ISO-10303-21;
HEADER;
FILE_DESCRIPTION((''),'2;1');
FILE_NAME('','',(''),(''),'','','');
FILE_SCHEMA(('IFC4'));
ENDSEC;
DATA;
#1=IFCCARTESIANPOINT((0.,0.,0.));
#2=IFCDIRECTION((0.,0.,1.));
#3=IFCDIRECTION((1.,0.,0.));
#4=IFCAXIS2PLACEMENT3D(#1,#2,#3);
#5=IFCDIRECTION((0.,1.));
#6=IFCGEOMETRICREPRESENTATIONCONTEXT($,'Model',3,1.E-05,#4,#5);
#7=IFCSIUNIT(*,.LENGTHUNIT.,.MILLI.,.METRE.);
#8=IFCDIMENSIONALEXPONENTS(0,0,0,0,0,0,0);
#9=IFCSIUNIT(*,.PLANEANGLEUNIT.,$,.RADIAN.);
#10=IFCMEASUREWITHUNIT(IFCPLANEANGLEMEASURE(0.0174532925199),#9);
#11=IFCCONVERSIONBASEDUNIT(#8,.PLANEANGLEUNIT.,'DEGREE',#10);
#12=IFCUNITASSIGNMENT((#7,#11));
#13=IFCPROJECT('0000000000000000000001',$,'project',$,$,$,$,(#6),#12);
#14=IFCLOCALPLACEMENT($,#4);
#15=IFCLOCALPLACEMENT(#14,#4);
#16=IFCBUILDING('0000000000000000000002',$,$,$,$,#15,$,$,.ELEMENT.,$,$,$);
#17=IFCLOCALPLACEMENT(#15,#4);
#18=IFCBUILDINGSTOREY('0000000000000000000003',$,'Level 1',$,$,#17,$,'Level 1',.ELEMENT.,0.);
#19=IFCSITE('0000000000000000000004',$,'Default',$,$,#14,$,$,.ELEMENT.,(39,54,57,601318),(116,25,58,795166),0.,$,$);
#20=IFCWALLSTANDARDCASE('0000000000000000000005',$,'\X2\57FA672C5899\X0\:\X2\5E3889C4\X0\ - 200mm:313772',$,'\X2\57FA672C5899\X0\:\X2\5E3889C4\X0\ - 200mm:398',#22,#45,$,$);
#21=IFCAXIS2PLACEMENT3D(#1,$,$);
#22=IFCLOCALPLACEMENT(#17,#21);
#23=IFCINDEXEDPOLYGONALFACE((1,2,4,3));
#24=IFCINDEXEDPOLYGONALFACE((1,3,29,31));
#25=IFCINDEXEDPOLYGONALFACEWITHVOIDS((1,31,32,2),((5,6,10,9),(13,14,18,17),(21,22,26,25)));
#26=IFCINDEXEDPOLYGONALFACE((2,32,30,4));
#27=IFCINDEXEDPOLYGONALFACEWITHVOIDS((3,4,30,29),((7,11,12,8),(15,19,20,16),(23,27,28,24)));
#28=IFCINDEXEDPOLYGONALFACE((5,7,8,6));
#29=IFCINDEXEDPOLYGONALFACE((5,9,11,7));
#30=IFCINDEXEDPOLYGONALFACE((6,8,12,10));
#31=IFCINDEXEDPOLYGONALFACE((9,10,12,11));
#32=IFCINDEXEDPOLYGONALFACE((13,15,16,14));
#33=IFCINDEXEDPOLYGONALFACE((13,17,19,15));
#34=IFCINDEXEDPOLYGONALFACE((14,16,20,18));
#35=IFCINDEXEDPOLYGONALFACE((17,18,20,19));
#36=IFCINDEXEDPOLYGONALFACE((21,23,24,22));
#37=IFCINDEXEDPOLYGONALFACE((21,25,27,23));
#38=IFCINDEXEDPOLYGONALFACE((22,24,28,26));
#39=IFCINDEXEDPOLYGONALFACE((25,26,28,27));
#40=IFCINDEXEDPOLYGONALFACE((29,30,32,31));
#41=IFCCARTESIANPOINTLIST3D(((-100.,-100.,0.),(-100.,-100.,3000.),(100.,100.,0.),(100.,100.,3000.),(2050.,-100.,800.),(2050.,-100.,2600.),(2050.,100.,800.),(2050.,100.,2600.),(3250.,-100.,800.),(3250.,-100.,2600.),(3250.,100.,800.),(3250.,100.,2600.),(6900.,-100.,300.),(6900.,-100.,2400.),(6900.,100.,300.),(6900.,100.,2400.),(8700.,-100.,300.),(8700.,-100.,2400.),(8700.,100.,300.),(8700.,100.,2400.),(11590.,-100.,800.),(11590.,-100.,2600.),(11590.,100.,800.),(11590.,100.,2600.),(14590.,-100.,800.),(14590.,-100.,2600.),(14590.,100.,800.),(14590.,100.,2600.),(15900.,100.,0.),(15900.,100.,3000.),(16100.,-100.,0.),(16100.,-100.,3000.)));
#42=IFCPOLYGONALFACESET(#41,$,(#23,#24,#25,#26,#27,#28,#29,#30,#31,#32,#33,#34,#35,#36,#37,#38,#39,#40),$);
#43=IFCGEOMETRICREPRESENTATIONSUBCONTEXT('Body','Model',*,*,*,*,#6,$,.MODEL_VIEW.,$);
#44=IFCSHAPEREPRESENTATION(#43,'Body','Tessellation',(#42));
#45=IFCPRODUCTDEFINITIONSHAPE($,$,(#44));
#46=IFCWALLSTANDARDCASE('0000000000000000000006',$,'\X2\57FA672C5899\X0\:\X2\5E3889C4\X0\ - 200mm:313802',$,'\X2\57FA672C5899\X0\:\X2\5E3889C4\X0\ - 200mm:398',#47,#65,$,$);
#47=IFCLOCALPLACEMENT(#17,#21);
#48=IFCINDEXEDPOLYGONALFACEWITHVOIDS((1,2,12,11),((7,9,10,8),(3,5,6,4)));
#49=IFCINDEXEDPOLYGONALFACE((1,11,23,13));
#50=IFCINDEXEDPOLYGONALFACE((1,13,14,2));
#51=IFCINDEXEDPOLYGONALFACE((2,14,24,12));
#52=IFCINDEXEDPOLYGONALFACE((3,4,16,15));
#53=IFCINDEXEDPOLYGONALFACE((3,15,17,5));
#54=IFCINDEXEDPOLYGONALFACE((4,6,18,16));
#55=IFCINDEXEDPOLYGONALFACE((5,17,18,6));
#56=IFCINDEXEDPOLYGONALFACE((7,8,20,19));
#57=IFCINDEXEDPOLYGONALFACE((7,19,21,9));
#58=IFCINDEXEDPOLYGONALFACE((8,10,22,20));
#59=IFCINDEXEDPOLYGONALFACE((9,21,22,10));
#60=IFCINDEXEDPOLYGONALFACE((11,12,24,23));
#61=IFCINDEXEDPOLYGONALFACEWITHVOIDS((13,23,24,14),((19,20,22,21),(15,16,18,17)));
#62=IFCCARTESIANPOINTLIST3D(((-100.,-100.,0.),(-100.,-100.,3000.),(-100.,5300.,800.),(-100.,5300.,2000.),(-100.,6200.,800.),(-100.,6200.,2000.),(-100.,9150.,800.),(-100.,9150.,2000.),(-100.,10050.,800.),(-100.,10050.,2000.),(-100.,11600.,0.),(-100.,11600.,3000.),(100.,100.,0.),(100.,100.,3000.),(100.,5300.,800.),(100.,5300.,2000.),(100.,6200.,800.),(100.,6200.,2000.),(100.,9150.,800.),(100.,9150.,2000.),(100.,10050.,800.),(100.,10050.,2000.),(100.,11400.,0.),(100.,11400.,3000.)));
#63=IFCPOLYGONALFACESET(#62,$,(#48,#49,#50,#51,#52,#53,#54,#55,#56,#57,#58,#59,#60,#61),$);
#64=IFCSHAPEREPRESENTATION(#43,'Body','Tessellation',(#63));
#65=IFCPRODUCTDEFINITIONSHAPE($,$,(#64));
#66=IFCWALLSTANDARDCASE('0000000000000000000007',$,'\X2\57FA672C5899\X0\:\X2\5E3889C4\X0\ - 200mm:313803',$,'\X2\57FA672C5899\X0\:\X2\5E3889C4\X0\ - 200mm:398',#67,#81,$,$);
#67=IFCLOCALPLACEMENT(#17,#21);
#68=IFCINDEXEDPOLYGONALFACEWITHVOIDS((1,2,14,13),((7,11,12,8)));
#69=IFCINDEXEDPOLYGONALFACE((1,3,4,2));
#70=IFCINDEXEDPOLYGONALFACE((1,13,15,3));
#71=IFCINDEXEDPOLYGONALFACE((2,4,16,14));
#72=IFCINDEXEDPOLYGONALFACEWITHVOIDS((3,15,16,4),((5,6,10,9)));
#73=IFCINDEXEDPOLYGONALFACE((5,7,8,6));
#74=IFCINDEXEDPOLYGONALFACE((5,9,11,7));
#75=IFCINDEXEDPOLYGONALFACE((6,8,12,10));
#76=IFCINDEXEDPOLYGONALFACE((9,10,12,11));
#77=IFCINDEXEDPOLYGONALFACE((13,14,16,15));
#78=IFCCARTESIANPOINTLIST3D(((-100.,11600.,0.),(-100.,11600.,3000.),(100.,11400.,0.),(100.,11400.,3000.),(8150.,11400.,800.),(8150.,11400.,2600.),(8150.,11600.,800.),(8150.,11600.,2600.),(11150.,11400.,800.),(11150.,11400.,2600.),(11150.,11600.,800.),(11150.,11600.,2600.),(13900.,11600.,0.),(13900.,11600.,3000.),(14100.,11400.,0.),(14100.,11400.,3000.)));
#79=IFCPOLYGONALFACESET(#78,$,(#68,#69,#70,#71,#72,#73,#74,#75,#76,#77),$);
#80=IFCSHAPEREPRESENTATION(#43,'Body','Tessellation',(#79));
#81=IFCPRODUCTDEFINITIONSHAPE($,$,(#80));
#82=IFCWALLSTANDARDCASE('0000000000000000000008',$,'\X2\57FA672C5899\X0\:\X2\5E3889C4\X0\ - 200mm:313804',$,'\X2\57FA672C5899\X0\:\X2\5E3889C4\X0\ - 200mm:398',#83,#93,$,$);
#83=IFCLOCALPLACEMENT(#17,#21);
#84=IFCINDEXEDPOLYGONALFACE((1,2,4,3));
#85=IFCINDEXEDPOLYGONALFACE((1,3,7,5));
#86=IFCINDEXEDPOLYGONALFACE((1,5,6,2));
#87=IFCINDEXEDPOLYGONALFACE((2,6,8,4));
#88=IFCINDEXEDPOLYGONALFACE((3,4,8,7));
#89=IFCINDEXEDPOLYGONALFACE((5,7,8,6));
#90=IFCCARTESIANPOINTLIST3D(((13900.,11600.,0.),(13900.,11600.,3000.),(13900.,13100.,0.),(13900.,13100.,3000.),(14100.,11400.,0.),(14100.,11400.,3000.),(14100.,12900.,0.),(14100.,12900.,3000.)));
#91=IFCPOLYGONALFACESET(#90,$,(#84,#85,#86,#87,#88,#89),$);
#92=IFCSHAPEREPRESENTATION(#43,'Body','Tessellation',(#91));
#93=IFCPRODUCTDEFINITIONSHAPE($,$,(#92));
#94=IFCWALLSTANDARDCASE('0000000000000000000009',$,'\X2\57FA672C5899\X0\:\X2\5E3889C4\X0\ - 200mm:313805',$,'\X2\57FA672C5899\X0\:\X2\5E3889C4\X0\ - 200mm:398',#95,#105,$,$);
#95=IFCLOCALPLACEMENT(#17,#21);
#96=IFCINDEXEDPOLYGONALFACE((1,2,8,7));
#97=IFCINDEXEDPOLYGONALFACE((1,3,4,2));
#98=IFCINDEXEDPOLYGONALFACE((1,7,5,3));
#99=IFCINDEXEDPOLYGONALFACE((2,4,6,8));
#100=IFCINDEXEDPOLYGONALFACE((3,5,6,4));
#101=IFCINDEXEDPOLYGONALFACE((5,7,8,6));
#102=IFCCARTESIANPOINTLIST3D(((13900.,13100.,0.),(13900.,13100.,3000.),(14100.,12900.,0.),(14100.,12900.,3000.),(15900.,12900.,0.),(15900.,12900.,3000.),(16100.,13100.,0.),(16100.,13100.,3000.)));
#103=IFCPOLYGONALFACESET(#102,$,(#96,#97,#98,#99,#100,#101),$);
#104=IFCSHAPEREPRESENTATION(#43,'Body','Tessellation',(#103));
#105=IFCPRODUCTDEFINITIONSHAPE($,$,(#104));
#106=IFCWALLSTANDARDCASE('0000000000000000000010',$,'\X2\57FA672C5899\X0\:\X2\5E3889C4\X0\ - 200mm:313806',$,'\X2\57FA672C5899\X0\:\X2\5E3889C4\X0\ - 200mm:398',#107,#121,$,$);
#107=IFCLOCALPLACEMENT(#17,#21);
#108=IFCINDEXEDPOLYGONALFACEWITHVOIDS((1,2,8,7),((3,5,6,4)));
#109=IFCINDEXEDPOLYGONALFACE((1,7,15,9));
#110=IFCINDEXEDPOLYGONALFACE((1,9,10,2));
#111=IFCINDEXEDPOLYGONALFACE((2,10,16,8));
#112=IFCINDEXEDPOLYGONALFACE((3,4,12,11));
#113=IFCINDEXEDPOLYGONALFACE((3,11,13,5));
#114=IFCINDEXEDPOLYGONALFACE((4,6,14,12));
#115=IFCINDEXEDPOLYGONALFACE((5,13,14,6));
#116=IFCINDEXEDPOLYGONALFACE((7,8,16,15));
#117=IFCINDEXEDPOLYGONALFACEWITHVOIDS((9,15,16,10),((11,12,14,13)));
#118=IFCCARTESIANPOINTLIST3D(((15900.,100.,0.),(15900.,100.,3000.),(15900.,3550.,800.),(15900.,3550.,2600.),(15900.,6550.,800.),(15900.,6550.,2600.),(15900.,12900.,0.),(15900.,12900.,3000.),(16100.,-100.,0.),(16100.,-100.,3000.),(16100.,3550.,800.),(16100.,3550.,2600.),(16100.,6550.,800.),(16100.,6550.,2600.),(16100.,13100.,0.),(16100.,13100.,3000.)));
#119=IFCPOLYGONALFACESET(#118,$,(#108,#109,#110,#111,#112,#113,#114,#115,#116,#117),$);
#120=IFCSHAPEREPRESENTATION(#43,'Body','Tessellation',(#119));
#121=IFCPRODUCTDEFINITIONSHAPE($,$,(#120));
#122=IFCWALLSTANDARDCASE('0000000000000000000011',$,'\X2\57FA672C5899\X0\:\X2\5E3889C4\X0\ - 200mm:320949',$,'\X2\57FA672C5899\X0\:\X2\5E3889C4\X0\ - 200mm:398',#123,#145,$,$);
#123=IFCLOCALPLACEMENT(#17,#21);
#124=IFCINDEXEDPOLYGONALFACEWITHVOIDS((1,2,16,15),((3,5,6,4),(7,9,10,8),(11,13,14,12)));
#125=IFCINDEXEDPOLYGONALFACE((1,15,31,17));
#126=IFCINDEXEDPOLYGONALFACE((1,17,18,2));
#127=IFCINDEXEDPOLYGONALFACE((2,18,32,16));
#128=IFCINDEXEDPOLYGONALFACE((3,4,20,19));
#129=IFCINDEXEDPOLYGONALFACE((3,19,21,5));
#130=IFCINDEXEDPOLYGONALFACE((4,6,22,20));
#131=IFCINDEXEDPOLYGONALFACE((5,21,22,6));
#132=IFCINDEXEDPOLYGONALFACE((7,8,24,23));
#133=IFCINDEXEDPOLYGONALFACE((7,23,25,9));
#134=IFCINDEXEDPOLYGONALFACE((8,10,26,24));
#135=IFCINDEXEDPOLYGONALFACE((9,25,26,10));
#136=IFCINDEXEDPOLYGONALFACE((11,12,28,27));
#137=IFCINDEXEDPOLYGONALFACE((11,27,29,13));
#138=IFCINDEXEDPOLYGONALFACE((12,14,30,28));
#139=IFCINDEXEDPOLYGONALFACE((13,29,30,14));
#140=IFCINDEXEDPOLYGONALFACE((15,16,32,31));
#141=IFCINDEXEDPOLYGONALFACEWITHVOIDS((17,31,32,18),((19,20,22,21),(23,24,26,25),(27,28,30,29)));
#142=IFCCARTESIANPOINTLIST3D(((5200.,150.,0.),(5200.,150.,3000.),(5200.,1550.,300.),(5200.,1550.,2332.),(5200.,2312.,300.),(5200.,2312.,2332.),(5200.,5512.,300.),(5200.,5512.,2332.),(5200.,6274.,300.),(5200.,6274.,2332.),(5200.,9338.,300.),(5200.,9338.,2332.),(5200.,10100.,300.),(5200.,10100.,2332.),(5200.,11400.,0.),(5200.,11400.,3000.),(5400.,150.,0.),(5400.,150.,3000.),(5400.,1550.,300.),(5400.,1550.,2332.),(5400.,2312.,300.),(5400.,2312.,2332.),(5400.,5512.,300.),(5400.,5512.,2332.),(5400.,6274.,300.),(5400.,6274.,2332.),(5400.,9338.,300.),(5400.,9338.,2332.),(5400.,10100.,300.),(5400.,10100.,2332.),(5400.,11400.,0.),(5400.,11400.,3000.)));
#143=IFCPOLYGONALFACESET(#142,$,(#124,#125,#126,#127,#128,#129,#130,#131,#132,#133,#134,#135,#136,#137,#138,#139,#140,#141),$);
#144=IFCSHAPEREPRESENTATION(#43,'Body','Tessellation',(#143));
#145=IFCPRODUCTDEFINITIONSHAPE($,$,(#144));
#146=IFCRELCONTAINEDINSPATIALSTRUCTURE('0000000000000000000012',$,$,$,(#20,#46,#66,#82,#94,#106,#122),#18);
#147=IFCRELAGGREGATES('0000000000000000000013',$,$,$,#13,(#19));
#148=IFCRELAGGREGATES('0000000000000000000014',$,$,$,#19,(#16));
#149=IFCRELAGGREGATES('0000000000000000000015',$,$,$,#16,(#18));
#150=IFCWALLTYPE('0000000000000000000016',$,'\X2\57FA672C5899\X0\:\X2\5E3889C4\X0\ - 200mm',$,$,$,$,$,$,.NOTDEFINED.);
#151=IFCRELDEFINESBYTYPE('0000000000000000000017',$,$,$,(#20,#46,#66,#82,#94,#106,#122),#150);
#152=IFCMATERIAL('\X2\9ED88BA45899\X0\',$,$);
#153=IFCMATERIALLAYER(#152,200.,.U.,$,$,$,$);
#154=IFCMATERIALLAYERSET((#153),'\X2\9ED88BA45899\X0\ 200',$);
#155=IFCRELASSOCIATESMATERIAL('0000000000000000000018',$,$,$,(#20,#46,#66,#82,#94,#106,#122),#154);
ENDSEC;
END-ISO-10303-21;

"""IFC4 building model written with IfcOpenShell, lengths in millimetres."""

from ifc_helpers import new_model, entity, si_unit, converted_unit, direction, frame, origin_with_axes, place, context, subcontext, project, spatial, polyline, outline, extrude, material, layer, layer_set, layer_usage, type_object, element, save


model = new_model("IFC4")

# Units and contexts
model_context = context("Model", 3, precision=1e-05, world=origin_with_axes(), true_north=direction((0.0, 1.0)))
body_context = subcontext(model_context, "Body", "Model", "MODEL_VIEW")
ifc_project = project(units=[si_unit("LENGTHUNIT", "METRE", prefix="MILLI"), converted_unit("PLANEANGLEUNIT", "DEGREE", entity("IfcPlaneAngleMeasure", 0.0174532925199), si_unit("PLANEANGLEUNIT", "RADIAN"), dimensions=[0, 0, 0, 0, 0, 0, 0])], contexts=[model_context])

# Site, building, storey
site_placement = place(None, origin_with_axes())
site = spatial("IfcSite", under=ifc_project, at=site_placement, Name="Default", CompositionType="ELEMENT", RefLatitude=(39, 54, 57, 601318), RefLongitude=(116, 25, 58, 795166), RefElevation=0.0)
building_placement = place(site_placement, origin_with_axes())
building = spatial("IfcBuilding", under=site, at=building_placement, CompositionType="ELEMENT")
storey_placement = place(building_placement, origin_with_axes())
storey = spatial("IfcBuildingStorey", under=building, at=storey_placement, Name="Level 1", LongName="Level 1", CompositionType="ELEMENT", Elevation=0.0)

# Walls, openings
ifc_material = material(Name="默认墙")
ifc_layer = layer(ifc_material, 200.0, ventilated="UNKNOWN")
ifc_layer_set = layer_set([ifc_layer], Name="默认墙 200")
ifc_layer_usage_1 = layer_usage(ifc_layer_set, "AXIS2", "POSITIVE", -100.0)
wall_type = type_object("IfcWallType", Name="基本墙:常规 - 200mm", PredefinedType="NOTDEFINED")
wall_1_placement = place(storey_placement, frame((16000.0, 0.0, 0.0), z_axis=(0.0, 0.0, 1.0), x_axis=(-1.0, 0.0, 0.0)))
wall_1 = element("IfcWallStandardCase", 1, at=wall_1_placement, inside=storey, type_object=wall_type, material=ifc_layer_usage_1, Name="基本墙:常规 - 200mm:313772", ObjectType="基本墙:常规 - 200mm:398", context=body_context, shape_type="SweptSolid", body=[
    extrude(outline(polyline([(100.0, -100.0), (15900.0, -100.0), (16100.0, 100.0), (-100.0, 100.0), (100.0, -100.0)])), origin_with_axes(), (0.0, 0.0, 1.0), 3000.0),
])
opening_1_placement = place(wall_1_placement, frame((13350.0, 0.0, 800.0), z_axis=(0.0, 0.0, 1.0), x_axis=(1.0, 0.0, 0.0)))
element("IfcOpeningElement", 2, at=opening_1_placement, cuts=wall_1, context=body_context, shape_type="SweptSolid", body=[
    extrude(outline(polyline([(-600.0, 0.0), (-600.0, -1800.0), (600.0, -1800.0), (600.0, 0.0), (-600.0, 0.0)])), frame((0.0, -100.0, 0.0), z_axis=(0.0, 1.0, 0.0), x_axis=(1.0, 0.0, 0.0)), (0.0, 0.0, 1.0), 200.0),
])
opening_2_placement = place(wall_1_placement, frame((2910.0, 0.0, 800.0), z_axis=(0.0, 0.0, 1.0), x_axis=(1.0, 0.0, 0.0)))
element("IfcOpeningElement", 3, at=opening_2_placement, cuts=wall_1, context=body_context, shape_type="SweptSolid", body=[
    extrude(outline(polyline([(-1500.0, 0.0), (-1500.0, -1800.0), (1500.0, -1800.0), (1500.0, 0.0), (-1500.0, 0.0)])), frame((0.0, -100.0, 0.0), z_axis=(0.0, 1.0, 0.0), x_axis=(1.0, 0.0, 0.0)), (0.0, 0.0, 1.0), 200.0),
])
opening_3_placement = place(wall_1_placement, frame((8200.0, 0.0, 300.0), z_axis=(0.0, 0.0, 1.0), x_axis=(1.0, 0.0, 0.0)))
element("IfcOpeningElement", 4, at=opening_3_placement, cuts=wall_1, context=body_context, shape_type="SweptSolid", body=[
    extrude(outline(polyline([(-900.0, 0.0), (-900.0, -2100.0), (900.0, -2100.0), (900.0, 0.0), (-900.0, 0.0)])), frame((0.0, -100.0, 0.0), z_axis=(0.0, 1.0, 0.0), x_axis=(1.0, 0.0, 0.0)), (0.0, 0.0, 1.0), 200.0),
])
ifc_layer_usage_2 = layer_usage(ifc_layer_set, "AXIS2", "POSITIVE", -100.0)
wall_2_placement = place(storey_placement, frame((0.0, 0.0, 0.0), z_axis=(0.0, 0.0, 1.0), x_axis=(0.0, 1.0, 0.0)))
wall_2 = element("IfcWallStandardCase", 5, at=wall_2_placement, inside=storey, type_object=wall_type, material=ifc_layer_usage_2, Name="基本墙:常规 - 200mm:313802", ObjectType="基本墙:常规 - 200mm:398", context=body_context, shape_type="SweptSolid", body=[
    extrude(outline(polyline([(100.0, -100.0), (11400.0, -100.0), (11600.0, 100.0), (-100.0, 100.0), (100.0, -100.0)])), origin_with_axes(), (0.0, 0.0, 1.0), 3000.0),
])
opening_4_placement = place(wall_2_placement, frame((5750.0, 0.0, 800.0), z_axis=(0.0, 0.0, 1.0), x_axis=(1.0, 0.0, 0.0)))
element("IfcOpeningElement", 6, at=opening_4_placement, cuts=wall_2, context=body_context, shape_type="SweptSolid", body=[
    extrude(outline(polyline([(450.0, -1200.0), (450.0, 0.0), (-450.0, 0.0), (-450.0, -1200.0), (450.0, -1200.0)])), frame((0.0, 100.0, 0.0), z_axis=(0.0, -1.0, 0.0), x_axis=(-1.0, 0.0, 0.0)), (0.0, 0.0, 1.0), 200.0),
])
opening_5_placement = place(wall_2_placement, frame((9600.0, 0.0, 800.0), z_axis=(0.0, 0.0, 1.0), x_axis=(1.0, 0.0, 0.0)))
element("IfcOpeningElement", 7, at=opening_5_placement, cuts=wall_2, context=body_context, shape_type="SweptSolid", body=[
    extrude(outline(polyline([(450.0, -1200.0), (450.0, 0.0), (-450.0, 0.0), (-450.0, -1200.0), (450.0, -1200.0)])), frame((0.0, 100.0, 0.0), z_axis=(0.0, -1.0, 0.0), x_axis=(-1.0, 0.0, 0.0)), (0.0, 0.0, 1.0), 200.0),
])

# Wall, opening
ifc_layer_usage_3 = layer_usage(ifc_layer_set, "AXIS2", "POSITIVE", -100.0)
wall_3_placement = place(storey_placement, frame((0.0, 11500.0, 0.0), z_axis=(0.0, 0.0, 1.0), x_axis=(1.0, 0.0, 0.0)))
wall_3 = element("IfcWallStandardCase", 8, at=wall_3_placement, inside=storey, type_object=wall_type, material=ifc_layer_usage_3, Name="基本墙:常规 - 200mm:313803", ObjectType="基本墙:常规 - 200mm:398", context=body_context, shape_type="SweptSolid", body=[
    extrude(outline(polyline([(100.0, -100.0), (14100.0, -100.0), (13900.0, 100.0), (-100.0, 100.0), (100.0, -100.0)])), origin_with_axes(), (0.0, 0.0, 1.0), 3000.0),
])
opening_6_placement = place(wall_3_placement, frame((9650.0, 0.0, 800.0), z_axis=(0.0, 0.0, 1.0), x_axis=(1.0, 0.0, 0.0)))
element("IfcOpeningElement", 9, at=opening_6_placement, cuts=wall_3, context=body_context, shape_type="SweptSolid", body=[
    extrude(outline(polyline([(-1500.0, 0.0), (-1500.0, -1800.0), (1500.0, -1800.0), (1500.0, 0.0), (-1500.0, 0.0)])), frame((0.0, -100.0, 0.0), z_axis=(0.0, 1.0, 0.0), x_axis=(1.0, 0.0, 0.0)), (0.0, 0.0, 1.0), 200.0),
])

# Walls
ifc_layer_usage_4 = layer_usage(ifc_layer_set, "AXIS2", "POSITIVE", -100.0)
wall_4_placement = place(storey_placement, frame((14000.0, 11500.0, 0.0), z_axis=(0.0, 0.0, 1.0), x_axis=(0.0, 1.0, 0.0)))
element("IfcWallStandardCase", 10, at=wall_4_placement, inside=storey, type_object=wall_type, material=ifc_layer_usage_4, Name="基本墙:常规 - 200mm:313804", ObjectType="基本墙:常规 - 200mm:398", context=body_context, shape_type="SweptSolid", body=[
    extrude(outline(polyline([(-100.0, -100.0), (1400.0, -100.0), (1600.0, 100.0), (100.0, 100.0), (-100.0, -100.0)])), origin_with_axes(), (0.0, 0.0, 1.0), 3000.0),
])
ifc_layer_usage_5 = layer_usage(ifc_layer_set, "AXIS2", "POSITIVE", -100.0)
wall_5_placement = place(storey_placement, frame((14000.0, 13000.0, 0.0), z_axis=(0.0, 0.0, 1.0), x_axis=(1.0, 0.0, 0.0)))
element("IfcWallStandardCase", 11, at=wall_5_placement, inside=storey, type_object=wall_type, material=ifc_layer_usage_5, Name="基本墙:常规 - 200mm:313805", ObjectType="基本墙:常规 - 200mm:398", context=body_context, shape_type="SweptSolid", body=[
    extrude(outline(polyline([(100.0, -100.0), (1900.0, -100.0), (2100.0, 100.0), (-100.0, 100.0), (100.0, -100.0)])), origin_with_axes(), (0.0, 0.0, 1.0), 3000.0),
])

# Wall, opening
ifc_layer_usage_6 = layer_usage(ifc_layer_set, "AXIS2", "POSITIVE", -100.0)
wall_6_placement = place(storey_placement, frame((16000.0, 13000.0, 0.0), z_axis=(0.0, 0.0, 1.0), x_axis=(0.0, -1.0, 0.0)))
wall_6 = element("IfcWallStandardCase", 12, at=wall_6_placement, inside=storey, type_object=wall_type, material=ifc_layer_usage_6, Name="基本墙:常规 - 200mm:313806", ObjectType="基本墙:常规 - 200mm:398", context=body_context, shape_type="SweptSolid", body=[
    extrude(outline(polyline([(100.0, -100.0), (12900.0, -100.0), (13100.0, 100.0), (-100.0, 100.0), (100.0, -100.0)])), origin_with_axes(), (0.0, 0.0, 1.0), 3000.0),
])
opening_7_placement = place(wall_6_placement, frame((7950.0, 0.0, 800.0), z_axis=(0.0, 0.0, 1.0), x_axis=(1.0, 0.0, 0.0)))
element("IfcOpeningElement", 13, at=opening_7_placement, cuts=wall_6, context=body_context, shape_type="SweptSolid", body=[
    extrude(outline(polyline([(-1500.0, 0.0), (-1500.0, -1800.0), (1500.0, -1800.0), (1500.0, 0.0), (-1500.0, 0.0)])), frame((0.0, -100.0, 0.0), z_axis=(0.0, 1.0, 0.0), x_axis=(1.0, 0.0, 0.0)), (0.0, 0.0, 1.0), 200.0),
])

# Wall, openings
ifc_layer_usage_7 = layer_usage(ifc_layer_set, "AXIS2", "POSITIVE", -100.0)
wall_7_placement = place(storey_placement, frame((5300.0, 11500.0, 0.0), z_axis=(0.0, 0.0, 1.0), x_axis=(0.0, -1.0, 0.0)))
wall_7 = element("IfcWallStandardCase", 14, at=wall_7_placement, inside=storey, type_object=wall_type, material=ifc_layer_usage_7, Name="基本墙:常规 - 200mm:320949", ObjectType="基本墙:常规 - 200mm:398", context=body_context, shape_type="SweptSolid", body=[
    extrude(outline(polyline([(100.0, -100.0), (11350.0, -100.0), (11350.0, 100.0), (100.0, 100.0), (100.0, -100.0)])), origin_with_axes(), (0.0, 0.0, 1.0), 3000.0),
])
opening_8_placement = place(wall_7_placement, frame((9569.0, 0.0, 300.0), z_axis=(0.0, 0.0, 1.0), x_axis=(1.0, 0.0, 0.0)))
element("IfcOpeningElement", 15, at=opening_8_placement, cuts=wall_7, context=body_context, shape_type="SweptSolid", body=[
    extrude(outline(polyline([(-381.0, -2032.0), (381.0, -2032.0), (381.0, 0.0), (-381.0, 0.0), (-381.0, -2032.0)])), frame((0.0, -100.0, 0.0), z_axis=(0.0, 1.0, 0.0), x_axis=(1.0, 0.0, 0.0)), (0.0, 0.0, 1.0), 200.0),
])
opening_9_placement = place(wall_7_placement, frame((5607.0, 0.0, 300.0), z_axis=(0.0, 0.0, 1.0), x_axis=(1.0, 0.0, 0.0)))
element("IfcOpeningElement", 16, at=opening_9_placement, cuts=wall_7, context=body_context, shape_type="SweptSolid", body=[
    extrude(outline(polyline([(-381.0, -2032.0), (381.0, -2032.0), (381.0, 0.0), (-381.0, 0.0), (-381.0, -2032.0)])), frame((0.0, -100.0, 0.0), z_axis=(0.0, 1.0, 0.0), x_axis=(1.0, 0.0, 0.0)), (0.0, 0.0, 1.0), 200.0),
])
opening_10_placement = place(wall_7_placement, frame((1781.0, 0.0, 300.0), z_axis=(0.0, 0.0, 1.0), x_axis=(1.0, 0.0, 0.0)))
element("IfcOpeningElement", 17, at=opening_10_placement, cuts=wall_7, context=body_context, shape_type="SweptSolid", body=[
    extrude(outline(polyline([(-381.0, -2032.0), (381.0, -2032.0), (381.0, 0.0), (-381.0, 0.0), (-381.0, -2032.0)])), frame((0.0, -100.0, 0.0), z_axis=(0.0, 1.0, 0.0), x_axis=(1.0, 0.0, 0.0)), (0.0, 0.0, 1.0), 200.0),
])

save(model, "model.ifc")
